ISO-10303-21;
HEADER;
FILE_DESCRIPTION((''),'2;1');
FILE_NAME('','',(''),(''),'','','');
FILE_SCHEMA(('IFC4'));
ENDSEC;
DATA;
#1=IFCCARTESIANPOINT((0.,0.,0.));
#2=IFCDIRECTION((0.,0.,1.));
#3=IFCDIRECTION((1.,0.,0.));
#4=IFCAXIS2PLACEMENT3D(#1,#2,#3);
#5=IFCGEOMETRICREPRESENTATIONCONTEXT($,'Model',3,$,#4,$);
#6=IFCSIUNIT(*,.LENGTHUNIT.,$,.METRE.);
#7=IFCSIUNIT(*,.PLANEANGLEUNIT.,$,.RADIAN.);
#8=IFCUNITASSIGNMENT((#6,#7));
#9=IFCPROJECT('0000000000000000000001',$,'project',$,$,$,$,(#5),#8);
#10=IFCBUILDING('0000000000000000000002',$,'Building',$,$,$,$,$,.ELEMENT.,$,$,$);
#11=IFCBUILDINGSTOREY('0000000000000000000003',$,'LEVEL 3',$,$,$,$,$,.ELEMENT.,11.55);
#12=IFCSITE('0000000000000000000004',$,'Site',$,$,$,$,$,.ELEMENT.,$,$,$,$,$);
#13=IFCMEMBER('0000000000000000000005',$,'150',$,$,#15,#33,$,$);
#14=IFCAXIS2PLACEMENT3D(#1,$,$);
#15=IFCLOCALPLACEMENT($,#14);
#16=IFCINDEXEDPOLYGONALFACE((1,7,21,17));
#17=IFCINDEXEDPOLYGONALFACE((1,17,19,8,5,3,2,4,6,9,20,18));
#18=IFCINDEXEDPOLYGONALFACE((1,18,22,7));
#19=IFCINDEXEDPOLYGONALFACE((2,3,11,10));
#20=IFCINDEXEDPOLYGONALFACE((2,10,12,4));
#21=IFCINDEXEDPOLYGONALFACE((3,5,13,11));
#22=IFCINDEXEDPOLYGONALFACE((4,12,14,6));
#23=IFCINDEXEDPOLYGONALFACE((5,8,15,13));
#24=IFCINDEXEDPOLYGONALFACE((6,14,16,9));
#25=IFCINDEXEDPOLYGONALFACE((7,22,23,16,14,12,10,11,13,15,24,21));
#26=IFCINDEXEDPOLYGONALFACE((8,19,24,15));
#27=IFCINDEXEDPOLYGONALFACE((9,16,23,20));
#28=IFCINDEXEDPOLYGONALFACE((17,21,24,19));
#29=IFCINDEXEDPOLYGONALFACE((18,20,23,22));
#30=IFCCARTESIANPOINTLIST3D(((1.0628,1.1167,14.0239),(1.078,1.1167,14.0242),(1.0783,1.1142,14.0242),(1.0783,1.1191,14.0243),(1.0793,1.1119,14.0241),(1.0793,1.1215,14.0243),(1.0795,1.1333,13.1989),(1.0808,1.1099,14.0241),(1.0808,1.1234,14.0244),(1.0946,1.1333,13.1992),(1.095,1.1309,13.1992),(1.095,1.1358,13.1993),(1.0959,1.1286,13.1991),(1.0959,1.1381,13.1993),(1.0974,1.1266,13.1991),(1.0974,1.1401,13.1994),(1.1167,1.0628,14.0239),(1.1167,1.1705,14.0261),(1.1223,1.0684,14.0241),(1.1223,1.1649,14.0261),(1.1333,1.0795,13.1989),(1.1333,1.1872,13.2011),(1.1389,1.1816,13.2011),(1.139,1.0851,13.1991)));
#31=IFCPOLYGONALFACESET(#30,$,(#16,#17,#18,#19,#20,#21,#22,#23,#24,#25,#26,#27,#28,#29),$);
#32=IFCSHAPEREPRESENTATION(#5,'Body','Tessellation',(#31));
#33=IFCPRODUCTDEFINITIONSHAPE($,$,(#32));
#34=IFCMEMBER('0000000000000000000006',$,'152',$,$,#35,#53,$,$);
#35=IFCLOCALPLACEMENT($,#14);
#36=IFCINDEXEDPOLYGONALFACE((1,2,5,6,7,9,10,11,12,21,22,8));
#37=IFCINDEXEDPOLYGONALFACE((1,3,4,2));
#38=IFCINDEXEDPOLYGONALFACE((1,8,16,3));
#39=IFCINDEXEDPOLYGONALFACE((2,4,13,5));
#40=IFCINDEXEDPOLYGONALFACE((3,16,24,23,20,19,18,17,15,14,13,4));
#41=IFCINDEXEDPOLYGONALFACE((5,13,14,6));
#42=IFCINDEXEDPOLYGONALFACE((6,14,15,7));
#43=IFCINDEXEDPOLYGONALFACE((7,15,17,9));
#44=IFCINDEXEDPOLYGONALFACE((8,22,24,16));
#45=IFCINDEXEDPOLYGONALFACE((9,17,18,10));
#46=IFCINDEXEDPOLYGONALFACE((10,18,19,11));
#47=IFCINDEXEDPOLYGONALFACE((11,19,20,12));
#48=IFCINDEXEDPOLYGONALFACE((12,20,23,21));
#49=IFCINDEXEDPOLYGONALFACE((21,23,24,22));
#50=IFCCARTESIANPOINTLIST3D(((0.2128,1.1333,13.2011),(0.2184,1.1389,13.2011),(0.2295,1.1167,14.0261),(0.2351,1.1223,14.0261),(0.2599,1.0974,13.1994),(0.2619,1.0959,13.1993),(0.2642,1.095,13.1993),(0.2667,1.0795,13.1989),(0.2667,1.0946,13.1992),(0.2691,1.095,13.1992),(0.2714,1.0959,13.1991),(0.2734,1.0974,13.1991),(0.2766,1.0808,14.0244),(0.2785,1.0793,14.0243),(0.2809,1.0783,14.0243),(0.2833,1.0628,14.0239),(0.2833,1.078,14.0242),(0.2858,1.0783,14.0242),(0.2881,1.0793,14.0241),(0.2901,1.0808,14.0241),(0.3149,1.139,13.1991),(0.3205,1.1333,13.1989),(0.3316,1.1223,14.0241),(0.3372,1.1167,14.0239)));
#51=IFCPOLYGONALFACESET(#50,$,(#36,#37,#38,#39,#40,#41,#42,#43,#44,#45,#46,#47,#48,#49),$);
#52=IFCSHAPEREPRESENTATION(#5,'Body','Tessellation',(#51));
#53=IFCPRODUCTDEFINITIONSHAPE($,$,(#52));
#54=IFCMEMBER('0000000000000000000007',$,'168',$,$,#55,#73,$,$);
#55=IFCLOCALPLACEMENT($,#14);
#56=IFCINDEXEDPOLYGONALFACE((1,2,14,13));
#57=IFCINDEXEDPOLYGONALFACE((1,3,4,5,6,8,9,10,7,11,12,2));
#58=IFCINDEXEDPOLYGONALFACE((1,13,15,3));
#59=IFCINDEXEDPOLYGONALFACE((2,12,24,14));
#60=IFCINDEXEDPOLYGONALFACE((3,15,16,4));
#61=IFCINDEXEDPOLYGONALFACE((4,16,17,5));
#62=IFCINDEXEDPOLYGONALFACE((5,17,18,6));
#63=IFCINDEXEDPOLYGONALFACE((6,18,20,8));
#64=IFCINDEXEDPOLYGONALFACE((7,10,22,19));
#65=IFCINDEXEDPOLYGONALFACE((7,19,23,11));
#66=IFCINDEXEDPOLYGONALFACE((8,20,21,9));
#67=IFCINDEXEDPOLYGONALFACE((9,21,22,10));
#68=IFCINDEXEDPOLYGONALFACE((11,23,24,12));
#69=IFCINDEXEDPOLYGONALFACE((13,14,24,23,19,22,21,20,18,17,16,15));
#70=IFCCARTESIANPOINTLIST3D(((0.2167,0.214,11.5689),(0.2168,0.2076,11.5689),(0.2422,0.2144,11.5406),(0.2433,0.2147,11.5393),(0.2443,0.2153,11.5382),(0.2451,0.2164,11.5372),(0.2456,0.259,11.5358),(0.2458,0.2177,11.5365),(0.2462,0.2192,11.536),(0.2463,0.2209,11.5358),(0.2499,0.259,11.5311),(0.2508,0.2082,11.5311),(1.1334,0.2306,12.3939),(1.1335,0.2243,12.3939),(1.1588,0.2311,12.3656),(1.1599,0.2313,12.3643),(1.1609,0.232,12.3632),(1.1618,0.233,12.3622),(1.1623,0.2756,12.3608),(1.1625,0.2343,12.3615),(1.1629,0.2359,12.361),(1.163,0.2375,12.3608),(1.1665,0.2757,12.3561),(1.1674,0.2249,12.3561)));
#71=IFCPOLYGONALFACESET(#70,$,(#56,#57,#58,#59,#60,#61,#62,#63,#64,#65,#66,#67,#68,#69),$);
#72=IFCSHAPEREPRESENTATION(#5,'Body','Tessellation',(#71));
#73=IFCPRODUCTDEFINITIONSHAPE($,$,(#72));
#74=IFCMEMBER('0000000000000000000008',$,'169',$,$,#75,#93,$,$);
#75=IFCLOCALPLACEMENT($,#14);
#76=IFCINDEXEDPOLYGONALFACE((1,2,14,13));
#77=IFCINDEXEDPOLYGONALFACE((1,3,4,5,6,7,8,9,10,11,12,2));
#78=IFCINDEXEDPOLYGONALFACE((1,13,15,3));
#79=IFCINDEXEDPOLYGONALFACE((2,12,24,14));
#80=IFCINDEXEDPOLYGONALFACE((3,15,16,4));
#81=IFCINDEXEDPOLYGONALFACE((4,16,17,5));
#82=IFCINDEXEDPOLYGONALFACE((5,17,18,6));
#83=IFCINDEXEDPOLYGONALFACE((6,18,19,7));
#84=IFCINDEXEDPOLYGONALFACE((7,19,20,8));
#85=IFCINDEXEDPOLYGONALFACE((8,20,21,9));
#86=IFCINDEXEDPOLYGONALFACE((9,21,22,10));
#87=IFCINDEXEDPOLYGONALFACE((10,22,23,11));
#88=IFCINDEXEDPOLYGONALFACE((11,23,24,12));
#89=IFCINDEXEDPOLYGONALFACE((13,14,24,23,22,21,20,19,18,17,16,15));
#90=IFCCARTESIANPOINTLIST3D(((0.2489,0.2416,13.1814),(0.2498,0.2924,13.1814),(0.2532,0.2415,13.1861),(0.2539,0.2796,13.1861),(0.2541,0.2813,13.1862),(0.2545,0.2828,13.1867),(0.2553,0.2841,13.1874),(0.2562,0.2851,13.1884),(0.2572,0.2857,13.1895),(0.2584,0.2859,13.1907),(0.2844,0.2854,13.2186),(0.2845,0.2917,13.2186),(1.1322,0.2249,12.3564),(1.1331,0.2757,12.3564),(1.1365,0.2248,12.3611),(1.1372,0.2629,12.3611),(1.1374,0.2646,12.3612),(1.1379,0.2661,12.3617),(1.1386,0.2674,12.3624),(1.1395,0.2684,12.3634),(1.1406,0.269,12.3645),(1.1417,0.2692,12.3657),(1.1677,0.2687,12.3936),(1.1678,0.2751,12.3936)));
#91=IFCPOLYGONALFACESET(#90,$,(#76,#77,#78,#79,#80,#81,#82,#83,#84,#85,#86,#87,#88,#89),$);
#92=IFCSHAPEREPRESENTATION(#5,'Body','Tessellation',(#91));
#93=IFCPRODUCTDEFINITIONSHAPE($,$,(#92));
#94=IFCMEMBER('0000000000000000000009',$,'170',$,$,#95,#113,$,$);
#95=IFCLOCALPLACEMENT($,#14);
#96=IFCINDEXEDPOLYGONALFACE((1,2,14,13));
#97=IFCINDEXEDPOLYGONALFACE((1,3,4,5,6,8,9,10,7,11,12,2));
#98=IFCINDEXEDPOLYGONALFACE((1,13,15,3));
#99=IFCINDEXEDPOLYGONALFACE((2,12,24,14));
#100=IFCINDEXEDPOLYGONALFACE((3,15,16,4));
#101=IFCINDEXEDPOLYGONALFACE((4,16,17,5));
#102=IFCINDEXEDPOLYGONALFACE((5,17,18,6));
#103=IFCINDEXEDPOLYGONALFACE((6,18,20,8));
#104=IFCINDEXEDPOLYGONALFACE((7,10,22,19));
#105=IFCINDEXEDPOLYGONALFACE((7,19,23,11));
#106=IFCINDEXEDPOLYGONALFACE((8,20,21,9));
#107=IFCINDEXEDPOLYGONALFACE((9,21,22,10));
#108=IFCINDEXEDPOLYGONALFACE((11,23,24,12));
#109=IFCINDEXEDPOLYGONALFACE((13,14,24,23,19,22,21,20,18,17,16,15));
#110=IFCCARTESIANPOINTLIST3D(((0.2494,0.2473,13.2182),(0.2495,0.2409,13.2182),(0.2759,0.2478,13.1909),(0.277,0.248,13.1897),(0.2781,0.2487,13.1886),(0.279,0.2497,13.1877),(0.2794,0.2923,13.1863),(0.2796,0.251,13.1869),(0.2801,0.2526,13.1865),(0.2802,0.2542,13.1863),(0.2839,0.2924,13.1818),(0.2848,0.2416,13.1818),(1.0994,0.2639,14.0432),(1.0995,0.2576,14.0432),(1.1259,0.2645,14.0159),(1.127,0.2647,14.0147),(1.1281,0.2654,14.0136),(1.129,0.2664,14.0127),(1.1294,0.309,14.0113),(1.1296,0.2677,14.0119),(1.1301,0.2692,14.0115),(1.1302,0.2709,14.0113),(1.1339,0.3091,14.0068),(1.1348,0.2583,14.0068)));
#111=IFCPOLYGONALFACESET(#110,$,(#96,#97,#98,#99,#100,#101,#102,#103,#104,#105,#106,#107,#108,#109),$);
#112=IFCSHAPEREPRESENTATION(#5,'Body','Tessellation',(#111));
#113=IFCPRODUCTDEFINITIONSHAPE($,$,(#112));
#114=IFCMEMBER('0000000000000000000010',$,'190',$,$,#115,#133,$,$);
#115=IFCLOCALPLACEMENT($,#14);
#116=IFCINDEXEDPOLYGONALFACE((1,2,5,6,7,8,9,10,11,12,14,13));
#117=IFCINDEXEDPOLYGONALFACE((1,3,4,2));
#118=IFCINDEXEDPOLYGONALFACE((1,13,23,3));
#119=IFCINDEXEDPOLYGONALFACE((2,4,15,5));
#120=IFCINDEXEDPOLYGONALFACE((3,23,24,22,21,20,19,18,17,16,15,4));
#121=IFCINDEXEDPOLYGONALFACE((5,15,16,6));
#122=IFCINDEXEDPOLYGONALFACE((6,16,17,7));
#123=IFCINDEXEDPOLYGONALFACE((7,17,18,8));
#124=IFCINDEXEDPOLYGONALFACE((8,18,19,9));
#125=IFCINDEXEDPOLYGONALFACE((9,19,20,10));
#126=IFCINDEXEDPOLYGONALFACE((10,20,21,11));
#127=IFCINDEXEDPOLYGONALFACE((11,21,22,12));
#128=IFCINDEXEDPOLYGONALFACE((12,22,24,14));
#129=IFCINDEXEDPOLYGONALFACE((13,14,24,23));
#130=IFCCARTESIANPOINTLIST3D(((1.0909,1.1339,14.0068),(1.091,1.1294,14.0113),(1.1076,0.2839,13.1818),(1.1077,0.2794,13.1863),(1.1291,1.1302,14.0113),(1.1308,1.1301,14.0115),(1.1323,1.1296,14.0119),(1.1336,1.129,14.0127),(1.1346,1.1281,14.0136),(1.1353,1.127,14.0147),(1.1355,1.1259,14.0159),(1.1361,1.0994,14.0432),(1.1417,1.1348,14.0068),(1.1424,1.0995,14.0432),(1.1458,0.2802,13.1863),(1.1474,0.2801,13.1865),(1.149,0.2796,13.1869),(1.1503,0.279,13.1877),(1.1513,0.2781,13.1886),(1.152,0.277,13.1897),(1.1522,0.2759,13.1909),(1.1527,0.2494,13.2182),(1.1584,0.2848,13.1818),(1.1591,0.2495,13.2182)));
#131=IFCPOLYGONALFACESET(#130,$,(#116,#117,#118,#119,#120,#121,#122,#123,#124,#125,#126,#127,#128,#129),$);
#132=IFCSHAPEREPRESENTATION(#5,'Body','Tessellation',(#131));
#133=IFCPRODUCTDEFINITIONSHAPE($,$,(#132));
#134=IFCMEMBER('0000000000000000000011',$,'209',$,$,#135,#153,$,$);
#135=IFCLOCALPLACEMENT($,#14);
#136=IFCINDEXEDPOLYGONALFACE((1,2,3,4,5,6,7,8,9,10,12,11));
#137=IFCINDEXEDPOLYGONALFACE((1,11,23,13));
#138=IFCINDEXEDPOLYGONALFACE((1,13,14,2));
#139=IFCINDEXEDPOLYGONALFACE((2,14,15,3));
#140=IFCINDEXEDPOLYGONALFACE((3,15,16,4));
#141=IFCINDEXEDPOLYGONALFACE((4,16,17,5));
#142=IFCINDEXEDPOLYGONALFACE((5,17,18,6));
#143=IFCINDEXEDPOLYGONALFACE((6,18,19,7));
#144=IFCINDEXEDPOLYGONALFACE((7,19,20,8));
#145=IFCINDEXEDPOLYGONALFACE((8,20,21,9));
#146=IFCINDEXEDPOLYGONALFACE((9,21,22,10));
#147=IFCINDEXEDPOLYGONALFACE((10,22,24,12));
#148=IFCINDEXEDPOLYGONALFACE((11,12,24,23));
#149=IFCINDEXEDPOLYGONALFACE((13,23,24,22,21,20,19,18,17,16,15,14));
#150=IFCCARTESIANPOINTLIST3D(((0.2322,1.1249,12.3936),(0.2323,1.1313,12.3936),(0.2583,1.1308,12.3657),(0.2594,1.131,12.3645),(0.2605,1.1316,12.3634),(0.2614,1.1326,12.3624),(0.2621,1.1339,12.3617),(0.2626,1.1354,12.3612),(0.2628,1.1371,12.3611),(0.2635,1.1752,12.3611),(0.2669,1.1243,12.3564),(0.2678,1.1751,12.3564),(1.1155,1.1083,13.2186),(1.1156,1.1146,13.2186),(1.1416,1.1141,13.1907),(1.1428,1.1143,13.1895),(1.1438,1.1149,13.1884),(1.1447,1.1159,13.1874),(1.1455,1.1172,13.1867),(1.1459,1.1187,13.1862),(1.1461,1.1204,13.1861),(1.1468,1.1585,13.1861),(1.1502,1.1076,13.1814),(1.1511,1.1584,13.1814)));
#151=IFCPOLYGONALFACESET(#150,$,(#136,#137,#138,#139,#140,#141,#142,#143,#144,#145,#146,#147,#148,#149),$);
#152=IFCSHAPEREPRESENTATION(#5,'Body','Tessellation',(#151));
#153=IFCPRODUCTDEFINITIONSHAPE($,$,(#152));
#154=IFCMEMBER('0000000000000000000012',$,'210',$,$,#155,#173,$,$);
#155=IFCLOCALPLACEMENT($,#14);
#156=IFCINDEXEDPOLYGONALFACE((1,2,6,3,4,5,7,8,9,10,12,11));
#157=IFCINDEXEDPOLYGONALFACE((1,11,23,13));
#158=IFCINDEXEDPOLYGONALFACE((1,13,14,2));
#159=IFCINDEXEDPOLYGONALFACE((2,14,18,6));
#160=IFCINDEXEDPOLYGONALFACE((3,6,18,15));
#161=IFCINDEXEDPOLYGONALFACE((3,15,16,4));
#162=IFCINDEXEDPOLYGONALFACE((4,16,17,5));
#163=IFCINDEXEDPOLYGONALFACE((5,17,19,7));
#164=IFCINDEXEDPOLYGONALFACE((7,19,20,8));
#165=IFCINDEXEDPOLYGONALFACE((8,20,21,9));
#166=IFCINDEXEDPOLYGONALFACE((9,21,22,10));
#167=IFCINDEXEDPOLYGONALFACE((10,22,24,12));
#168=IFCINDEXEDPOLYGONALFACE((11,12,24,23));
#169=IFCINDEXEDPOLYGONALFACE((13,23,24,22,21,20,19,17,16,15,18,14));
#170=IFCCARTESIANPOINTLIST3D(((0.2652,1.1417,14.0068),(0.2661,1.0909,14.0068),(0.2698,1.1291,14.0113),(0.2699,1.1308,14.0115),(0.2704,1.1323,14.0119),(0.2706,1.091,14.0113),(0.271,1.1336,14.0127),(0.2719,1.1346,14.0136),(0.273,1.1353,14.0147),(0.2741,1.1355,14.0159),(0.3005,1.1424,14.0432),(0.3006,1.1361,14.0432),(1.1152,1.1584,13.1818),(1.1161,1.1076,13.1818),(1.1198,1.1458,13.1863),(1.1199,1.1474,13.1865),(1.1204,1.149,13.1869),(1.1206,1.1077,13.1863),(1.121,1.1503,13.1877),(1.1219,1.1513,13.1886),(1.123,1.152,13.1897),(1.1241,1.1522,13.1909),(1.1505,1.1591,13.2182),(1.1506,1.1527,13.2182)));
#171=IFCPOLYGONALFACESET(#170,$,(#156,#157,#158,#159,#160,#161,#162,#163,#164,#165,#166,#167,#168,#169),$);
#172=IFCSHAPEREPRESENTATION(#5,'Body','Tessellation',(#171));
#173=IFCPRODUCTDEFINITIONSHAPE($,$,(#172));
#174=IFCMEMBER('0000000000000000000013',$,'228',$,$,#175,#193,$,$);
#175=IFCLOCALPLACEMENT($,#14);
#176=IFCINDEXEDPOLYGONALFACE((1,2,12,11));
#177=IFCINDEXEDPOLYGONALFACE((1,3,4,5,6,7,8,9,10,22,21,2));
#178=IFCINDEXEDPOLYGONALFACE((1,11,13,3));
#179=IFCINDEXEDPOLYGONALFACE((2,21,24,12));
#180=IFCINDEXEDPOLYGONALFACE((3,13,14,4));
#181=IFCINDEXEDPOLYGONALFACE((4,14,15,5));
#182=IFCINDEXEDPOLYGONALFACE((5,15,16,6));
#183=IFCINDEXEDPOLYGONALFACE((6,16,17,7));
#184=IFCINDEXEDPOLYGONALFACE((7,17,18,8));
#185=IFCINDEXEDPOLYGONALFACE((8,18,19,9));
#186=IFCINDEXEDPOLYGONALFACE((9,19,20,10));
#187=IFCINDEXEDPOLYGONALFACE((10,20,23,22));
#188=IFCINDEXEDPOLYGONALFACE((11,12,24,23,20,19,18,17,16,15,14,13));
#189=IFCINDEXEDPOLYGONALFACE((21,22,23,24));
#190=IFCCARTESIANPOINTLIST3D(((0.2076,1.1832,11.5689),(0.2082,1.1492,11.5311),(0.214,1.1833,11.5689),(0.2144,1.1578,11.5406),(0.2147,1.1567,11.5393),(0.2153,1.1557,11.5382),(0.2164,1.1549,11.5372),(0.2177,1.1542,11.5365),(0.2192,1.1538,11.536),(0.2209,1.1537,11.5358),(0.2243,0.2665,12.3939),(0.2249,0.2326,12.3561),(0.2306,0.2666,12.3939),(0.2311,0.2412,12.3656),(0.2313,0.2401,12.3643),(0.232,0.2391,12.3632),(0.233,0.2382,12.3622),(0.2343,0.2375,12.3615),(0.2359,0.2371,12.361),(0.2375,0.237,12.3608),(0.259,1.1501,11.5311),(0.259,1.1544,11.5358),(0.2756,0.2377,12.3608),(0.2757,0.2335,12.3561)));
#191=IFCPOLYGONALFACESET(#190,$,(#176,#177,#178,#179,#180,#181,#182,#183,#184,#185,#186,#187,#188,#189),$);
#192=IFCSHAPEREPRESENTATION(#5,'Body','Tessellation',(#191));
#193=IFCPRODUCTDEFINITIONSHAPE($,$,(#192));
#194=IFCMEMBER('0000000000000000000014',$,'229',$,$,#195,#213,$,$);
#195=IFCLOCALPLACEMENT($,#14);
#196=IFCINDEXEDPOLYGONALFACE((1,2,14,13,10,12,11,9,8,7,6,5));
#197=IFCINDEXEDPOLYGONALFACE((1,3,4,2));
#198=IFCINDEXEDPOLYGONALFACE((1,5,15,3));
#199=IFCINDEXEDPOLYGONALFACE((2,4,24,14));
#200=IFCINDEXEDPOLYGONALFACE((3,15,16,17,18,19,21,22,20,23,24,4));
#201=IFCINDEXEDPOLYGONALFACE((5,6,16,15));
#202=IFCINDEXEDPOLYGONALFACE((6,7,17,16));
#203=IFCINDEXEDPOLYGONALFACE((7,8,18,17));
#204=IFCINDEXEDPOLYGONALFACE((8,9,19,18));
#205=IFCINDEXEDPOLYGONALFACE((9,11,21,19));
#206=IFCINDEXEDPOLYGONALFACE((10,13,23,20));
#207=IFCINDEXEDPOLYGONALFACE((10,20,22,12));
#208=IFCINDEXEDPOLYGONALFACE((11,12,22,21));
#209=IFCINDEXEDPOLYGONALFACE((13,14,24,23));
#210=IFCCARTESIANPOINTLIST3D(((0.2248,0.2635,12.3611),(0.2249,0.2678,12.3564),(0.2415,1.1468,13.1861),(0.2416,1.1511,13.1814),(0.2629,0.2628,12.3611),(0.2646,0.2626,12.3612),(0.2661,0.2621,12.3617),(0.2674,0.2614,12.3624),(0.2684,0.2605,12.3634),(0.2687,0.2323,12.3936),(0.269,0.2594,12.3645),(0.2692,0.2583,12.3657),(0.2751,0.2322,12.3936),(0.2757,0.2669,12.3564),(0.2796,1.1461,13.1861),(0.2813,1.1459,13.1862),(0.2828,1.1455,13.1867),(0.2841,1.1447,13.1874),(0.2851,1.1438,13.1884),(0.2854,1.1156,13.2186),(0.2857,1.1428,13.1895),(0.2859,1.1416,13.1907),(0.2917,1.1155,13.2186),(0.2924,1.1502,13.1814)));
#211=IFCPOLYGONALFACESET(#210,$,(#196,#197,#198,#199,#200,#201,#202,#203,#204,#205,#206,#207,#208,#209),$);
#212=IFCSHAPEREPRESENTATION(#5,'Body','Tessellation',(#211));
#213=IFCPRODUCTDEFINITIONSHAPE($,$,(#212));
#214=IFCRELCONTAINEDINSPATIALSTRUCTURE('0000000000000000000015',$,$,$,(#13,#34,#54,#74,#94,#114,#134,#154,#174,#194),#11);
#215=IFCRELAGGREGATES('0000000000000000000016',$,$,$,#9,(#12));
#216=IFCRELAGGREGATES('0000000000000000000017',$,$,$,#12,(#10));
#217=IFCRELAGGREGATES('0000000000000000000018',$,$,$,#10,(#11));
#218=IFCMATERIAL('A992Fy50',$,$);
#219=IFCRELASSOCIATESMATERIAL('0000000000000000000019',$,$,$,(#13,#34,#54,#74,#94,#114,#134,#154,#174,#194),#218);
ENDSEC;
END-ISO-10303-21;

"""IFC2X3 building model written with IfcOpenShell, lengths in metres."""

from ifc_helpers import new_model, si_unit, frame, origin_with_axes, origin_2d_with_axis, place, context, project, spatial, l_section, extrude, material, element, save


model = new_model("IFC2X3")

# Units and contexts
model_context = context("Model", 3, world=origin_with_axes())
ifc_project = project(units=[si_unit("LENGTHUNIT", "METRE"), si_unit("PLANEANGLEUNIT", "RADIAN")], contexts=[model_context])

# Site, building, storey
site = spatial("IfcSite", under=ifc_project, Name="Site", CompositionType="ELEMENT")
building = spatial("IfcBuilding", under=site, Name="Building", CompositionType="ELEMENT")
storey = spatial("IfcBuildingStorey", under=building, Name="LEVEL 3", CompositionType="ELEMENT", Elevation=11.55)

# Shared definitions
ifc_material = material(Name="A992Fy50")

# Members
for number, where, z_axis, x_axis, name in (
    (1, (1.1333, 1.1333, 13.2), (-0.020194, -0.020194, 0.999592), (0.707107, -0.707107, 0.0), "150"),
    (2, (0.2667, 1.1333, 13.2), (0.020194, -0.020194, 0.999592), (0.707107, 0.707107, 0.0), "152"),
):
    element("IfcMember", number, at=place(None, frame(where, z_axis=z_axis, x_axis=x_axis)), inside=storey, material=ifc_material, Name=name, context=model_context, shape_type="SweptSolid", body=[
        extrude(l_section(Depth=0.0762, Width=0.0762, Thickness=0.0079, FilletRadius=0.0096, at=origin_2d_with_axis()), origin_with_axes(), (0.0, 0.0, 1.0), 0.8253),
    ])
member_1_placement = place(None, frame((0.2333, 0.2333, 11.55), z_axis=(0.743226, 0.013513, 0.668904), x_axis=(-0.018179, 0.999835, 0.0)))
element("IfcMember", 3, at=member_1_placement, inside=storey, material=ifc_material, Name="168", context=model_context, shape_type="SweptSolid", body=[
    extrude(l_section(Depth=0.0508, Width=0.0508, Thickness=0.0063, FilletRadius=0.0063, at=origin_2d_with_axis()), origin_with_axes(), (0.0, 0.0, 1.0), 1.2334),
])
member_2_placement = place(None, frame((1.15, 0.25, 12.375), z_axis=(-0.730756, 0.013788, 0.682499), x_axis=(-0.018865, -0.999822, 0.0)))
element("IfcMember", 4, at=member_2_placement, inside=storey, material=ifc_material, Name="169", context=model_context, shape_type="SweptSolid", body=[
    extrude(l_section(Depth=0.0508, Width=0.0508, Thickness=0.0063, FilletRadius=0.0063, at=origin_2d_with_axis()), origin_with_axes(), (0.0, 0.0, 1.0), 1.2088),
])
for number, where, z_axis, x_axis, name in (
    (5, (0.2667, 0.2667, 13.2), (0.71751, 0.014069, 0.696406), (-0.019604, 0.999808, 0.0), "170"),
    (6, (1.1333, 0.2667, 13.2), (-0.014069, 0.71751, 0.696406), (-0.999808, -0.019604, 0.0), "190"),
):
    element("IfcMember", number, at=place(None, frame(where, z_axis=z_axis, x_axis=x_axis)), inside=storey, material=ifc_material, Name=name, context=model_context, shape_type="SweptSolid", body=[
        extrude(l_section(Depth=0.0508, Width=0.0508, Thickness=0.0063, FilletRadius=0.0063, at=origin_2d_with_axis()), origin_with_axes(), (0.0, 0.0, 1.0), 1.1847),
    ])
member_3_placement = place(None, frame((0.25, 1.15, 12.375), z_axis=(0.730756, -0.013788, 0.682499), x_axis=(0.018865, 0.999822, 0.0)))
element("IfcMember", 7, at=member_3_placement, inside=storey, material=ifc_material, Name="209", context=model_context, shape_type="SweptSolid", body=[
    extrude(l_section(Depth=0.0508, Width=0.0508, Thickness=0.0063, FilletRadius=0.0063, at=origin_2d_with_axis()), origin_with_axes(), (0.0, 0.0, 1.0), 1.2088),
])
member_4_placement = place(None, frame((1.1333, 1.1333, 13.2), z_axis=(-0.71751, -0.014069, 0.696406), x_axis=(0.019604, -0.999808, 0.0)))
element("IfcMember", 8, at=member_4_placement, inside=storey, material=ifc_material, Name="210", context=model_context, shape_type="SweptSolid", body=[
    extrude(l_section(Depth=0.0508, Width=0.0508, Thickness=0.0063, FilletRadius=0.0063, at=origin_2d_with_axis()), origin_with_axes(), (0.0, 0.0, 1.0), 1.1847),
])
member_5_placement = place(None, frame((0.2333, 1.1667, 11.55), z_axis=(0.013513, -0.743226, 0.668904), x_axis=(0.999835, 0.018179, 0.0)))
element("IfcMember", 9, at=member_5_placement, inside=storey, material=ifc_material, Name="228", context=model_context, shape_type="SweptSolid", body=[
    extrude(l_section(Depth=0.0508, Width=0.0508, Thickness=0.0063, FilletRadius=0.0063, at=origin_2d_with_axis()), origin_with_axes(), (0.0, 0.0, 1.0), 1.2334),
])
member_6_placement = place(None, frame((0.25, 0.25, 12.375), z_axis=(0.013788, 0.730756, 0.682499), x_axis=(-0.999822, 0.018865, 0.0)))
element("IfcMember", 10, at=member_6_placement, inside=storey, material=ifc_material, Name="229", context=model_context, shape_type="SweptSolid", body=[
    extrude(l_section(Depth=0.0508, Width=0.0508, Thickness=0.0063, FilletRadius=0.0063, at=origin_2d_with_axis()), origin_with_axes(), (0.0, 0.0, 1.0), 1.2088),
])

save(model, "model.ifc")
